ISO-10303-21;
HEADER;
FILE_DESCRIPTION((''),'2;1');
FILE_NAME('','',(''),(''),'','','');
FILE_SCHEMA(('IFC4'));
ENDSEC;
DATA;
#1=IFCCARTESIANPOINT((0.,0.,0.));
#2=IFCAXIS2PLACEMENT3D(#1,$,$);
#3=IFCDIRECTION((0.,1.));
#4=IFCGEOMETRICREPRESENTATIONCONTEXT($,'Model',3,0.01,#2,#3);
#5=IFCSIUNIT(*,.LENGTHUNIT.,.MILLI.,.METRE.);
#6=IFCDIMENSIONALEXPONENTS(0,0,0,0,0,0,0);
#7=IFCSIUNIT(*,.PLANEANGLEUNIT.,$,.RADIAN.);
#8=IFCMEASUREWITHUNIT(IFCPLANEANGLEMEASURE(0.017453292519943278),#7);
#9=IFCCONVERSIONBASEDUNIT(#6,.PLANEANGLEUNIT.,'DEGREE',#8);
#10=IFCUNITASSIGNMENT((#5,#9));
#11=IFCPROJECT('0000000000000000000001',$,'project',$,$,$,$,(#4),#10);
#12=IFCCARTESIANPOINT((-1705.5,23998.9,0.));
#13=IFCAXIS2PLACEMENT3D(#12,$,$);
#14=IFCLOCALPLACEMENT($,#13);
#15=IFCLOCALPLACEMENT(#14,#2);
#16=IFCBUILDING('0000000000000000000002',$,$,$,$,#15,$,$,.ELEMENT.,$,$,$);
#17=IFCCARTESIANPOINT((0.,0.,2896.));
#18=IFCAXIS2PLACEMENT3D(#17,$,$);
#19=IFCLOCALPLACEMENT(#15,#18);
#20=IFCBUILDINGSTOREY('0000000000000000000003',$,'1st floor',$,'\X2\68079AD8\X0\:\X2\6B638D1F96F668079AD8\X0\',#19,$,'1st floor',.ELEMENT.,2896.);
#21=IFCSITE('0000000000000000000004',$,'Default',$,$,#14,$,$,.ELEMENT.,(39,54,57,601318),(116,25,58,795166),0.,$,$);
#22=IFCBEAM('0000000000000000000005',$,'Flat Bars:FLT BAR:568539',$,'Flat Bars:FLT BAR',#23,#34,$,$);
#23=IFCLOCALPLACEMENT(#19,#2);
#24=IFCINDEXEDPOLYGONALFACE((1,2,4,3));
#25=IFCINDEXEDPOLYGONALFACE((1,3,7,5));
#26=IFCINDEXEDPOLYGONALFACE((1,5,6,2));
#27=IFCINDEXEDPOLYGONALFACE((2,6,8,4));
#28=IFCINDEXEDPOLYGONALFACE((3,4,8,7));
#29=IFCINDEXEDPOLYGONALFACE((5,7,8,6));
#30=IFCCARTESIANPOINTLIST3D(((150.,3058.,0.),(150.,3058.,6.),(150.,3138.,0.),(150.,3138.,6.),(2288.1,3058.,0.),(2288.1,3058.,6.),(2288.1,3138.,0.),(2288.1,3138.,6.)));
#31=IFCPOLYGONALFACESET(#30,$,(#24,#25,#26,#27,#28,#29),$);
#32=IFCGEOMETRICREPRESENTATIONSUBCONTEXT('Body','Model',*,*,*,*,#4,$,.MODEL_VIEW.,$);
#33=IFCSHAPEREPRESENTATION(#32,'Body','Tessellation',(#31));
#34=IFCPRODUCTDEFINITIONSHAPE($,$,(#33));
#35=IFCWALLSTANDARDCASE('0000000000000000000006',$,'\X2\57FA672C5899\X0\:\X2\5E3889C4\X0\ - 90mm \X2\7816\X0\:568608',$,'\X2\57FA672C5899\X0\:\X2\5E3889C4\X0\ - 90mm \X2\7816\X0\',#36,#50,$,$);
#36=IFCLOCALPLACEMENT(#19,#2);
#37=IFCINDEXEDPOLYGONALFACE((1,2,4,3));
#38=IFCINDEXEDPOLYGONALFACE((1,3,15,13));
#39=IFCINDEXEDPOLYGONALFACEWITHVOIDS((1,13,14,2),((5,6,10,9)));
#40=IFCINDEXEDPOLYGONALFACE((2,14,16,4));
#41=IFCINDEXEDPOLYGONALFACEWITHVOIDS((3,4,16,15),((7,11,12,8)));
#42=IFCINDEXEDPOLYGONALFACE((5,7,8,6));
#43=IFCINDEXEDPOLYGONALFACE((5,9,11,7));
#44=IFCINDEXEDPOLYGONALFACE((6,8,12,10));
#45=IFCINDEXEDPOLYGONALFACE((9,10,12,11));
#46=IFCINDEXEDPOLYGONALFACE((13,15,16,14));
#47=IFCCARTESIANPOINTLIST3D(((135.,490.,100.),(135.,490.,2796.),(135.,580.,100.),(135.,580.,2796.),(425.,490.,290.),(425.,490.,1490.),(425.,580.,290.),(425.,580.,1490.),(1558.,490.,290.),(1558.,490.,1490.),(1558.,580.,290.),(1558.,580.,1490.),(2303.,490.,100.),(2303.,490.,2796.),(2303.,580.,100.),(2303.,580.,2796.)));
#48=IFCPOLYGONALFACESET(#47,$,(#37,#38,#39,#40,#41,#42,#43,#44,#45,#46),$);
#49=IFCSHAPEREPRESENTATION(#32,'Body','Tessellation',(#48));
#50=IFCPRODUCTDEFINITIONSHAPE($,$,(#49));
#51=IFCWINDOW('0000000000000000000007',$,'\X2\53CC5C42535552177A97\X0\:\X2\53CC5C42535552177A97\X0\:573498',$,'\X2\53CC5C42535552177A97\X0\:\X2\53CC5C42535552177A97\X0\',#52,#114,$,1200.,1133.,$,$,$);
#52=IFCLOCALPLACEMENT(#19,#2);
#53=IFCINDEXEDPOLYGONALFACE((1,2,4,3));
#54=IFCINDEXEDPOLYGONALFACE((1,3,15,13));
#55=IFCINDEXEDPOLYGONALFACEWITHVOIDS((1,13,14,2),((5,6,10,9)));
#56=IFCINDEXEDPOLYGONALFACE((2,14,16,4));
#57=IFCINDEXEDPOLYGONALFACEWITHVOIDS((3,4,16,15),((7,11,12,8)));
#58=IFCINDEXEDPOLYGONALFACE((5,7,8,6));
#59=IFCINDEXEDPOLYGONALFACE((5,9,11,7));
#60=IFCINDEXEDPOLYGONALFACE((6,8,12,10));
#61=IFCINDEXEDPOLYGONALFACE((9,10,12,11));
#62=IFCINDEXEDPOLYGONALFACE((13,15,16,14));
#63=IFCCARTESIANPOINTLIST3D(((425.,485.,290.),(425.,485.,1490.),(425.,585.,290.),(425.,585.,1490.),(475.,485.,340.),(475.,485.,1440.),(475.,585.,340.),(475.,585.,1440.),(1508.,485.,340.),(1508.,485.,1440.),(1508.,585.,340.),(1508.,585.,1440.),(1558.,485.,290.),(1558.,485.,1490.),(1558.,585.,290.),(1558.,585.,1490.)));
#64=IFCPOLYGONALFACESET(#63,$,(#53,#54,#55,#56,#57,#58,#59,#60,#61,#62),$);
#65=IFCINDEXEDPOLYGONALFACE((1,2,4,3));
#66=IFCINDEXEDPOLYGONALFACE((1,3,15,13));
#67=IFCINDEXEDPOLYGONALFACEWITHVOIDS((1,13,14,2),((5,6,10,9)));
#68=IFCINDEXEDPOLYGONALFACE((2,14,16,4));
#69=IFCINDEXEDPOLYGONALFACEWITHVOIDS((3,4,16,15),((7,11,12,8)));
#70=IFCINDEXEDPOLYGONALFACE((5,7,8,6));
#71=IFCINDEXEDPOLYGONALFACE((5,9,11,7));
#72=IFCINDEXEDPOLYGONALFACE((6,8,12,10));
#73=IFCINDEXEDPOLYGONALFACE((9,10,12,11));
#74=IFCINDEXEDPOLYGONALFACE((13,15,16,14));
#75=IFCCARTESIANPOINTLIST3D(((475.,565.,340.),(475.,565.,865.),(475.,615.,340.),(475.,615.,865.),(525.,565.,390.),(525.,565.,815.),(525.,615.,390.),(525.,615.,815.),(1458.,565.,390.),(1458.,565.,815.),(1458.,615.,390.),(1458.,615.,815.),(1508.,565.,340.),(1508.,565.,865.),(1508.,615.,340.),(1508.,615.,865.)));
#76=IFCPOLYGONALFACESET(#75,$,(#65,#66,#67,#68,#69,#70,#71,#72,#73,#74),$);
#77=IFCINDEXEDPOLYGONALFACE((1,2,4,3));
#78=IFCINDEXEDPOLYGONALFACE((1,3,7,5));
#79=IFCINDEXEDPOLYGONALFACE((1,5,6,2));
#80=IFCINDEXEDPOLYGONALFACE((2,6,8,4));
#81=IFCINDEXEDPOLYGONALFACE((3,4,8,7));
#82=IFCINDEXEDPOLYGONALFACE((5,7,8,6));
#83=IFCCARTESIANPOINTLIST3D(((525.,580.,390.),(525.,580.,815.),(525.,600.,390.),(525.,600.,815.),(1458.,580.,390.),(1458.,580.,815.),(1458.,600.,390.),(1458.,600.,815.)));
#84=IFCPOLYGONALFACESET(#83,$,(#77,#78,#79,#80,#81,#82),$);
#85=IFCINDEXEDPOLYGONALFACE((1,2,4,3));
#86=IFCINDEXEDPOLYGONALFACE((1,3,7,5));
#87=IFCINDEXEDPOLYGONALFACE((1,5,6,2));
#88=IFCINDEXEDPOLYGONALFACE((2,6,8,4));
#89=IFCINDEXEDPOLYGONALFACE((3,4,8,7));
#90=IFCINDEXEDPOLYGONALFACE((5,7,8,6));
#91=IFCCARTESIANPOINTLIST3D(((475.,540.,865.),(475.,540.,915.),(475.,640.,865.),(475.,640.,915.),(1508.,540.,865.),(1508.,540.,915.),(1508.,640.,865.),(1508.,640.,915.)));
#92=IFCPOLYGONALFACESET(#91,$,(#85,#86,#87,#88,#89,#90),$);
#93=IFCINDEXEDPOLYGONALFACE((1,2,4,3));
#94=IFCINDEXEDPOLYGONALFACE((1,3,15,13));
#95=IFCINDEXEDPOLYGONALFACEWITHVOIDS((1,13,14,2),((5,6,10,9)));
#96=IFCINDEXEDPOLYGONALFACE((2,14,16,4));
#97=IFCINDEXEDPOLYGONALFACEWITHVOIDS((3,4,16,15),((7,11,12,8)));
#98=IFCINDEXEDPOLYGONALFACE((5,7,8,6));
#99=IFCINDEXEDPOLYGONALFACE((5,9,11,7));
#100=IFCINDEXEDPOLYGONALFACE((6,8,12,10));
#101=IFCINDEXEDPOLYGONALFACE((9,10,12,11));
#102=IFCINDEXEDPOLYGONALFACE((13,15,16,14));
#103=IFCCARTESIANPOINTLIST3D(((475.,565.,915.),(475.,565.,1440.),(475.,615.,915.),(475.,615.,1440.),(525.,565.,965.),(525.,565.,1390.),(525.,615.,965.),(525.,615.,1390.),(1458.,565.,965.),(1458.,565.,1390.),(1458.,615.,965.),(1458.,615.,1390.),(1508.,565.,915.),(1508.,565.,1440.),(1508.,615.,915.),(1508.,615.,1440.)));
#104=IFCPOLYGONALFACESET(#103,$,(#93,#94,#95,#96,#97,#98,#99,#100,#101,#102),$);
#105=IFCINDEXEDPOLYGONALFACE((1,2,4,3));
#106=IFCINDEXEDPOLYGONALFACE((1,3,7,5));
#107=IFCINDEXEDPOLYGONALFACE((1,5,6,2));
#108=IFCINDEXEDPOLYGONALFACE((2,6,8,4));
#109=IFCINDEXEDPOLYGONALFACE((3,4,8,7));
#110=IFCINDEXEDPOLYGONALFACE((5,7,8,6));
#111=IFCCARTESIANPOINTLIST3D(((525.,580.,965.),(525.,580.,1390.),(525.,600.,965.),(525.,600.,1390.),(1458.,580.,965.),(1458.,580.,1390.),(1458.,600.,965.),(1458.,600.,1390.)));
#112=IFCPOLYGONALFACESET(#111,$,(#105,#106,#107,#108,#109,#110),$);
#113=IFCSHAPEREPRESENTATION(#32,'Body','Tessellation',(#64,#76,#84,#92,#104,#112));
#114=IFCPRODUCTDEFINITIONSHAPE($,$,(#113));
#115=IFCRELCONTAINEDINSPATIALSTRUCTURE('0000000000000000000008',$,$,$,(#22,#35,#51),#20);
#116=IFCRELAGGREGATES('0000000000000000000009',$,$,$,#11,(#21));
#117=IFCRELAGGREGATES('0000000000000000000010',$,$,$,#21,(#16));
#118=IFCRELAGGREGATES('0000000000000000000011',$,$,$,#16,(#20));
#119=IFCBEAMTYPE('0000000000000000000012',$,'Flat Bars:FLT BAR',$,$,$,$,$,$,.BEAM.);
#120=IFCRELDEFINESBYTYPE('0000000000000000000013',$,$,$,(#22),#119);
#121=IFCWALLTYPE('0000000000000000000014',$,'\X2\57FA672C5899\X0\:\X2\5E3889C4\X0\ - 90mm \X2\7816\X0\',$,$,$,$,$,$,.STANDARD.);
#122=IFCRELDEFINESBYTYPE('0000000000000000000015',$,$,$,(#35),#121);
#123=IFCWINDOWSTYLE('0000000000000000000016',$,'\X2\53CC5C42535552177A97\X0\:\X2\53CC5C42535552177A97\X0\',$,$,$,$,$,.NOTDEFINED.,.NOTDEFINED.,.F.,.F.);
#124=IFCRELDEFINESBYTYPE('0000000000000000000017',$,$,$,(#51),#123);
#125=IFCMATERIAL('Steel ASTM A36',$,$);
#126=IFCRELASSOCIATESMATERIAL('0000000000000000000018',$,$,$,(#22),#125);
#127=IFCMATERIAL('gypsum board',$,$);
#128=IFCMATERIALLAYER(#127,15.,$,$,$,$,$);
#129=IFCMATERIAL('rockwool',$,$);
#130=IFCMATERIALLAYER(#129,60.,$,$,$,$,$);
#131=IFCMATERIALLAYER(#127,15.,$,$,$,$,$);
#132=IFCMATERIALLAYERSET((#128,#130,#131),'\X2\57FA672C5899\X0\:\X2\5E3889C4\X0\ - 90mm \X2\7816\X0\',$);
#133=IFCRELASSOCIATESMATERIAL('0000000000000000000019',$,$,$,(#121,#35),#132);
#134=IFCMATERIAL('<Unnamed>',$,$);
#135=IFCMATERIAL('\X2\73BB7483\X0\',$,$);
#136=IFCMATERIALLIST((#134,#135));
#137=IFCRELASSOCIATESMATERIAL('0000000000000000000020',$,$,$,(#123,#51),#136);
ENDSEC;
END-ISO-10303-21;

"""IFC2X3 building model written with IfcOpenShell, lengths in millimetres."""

from ifc_helpers import new_model, entity, si_unit, converted_unit, direction, frame, frame_2d, origin, origin_2d_with_axis, place, context, subcontext, project, spatial, polyline, rectangle, outline, extrude, source, transform, mapped, material, material_list, layer, layer_set, layer_usage, type_object, type_shapes, element, fill, save


model = new_model("IFC2X3")

# Units and contexts
model_context = context("Model", 3, precision=0.01, world=origin(), true_north=direction((0.0, 1.0)))
body_context = subcontext(model_context, "Body", "Model", "MODEL_VIEW")
ifc_project = project(units=[si_unit("LENGTHUNIT", "METRE", prefix="MILLI"), converted_unit("PLANEANGLEUNIT", "DEGREE", entity("IfcPlaneAngleMeasure", 0.017453292519943278), si_unit("PLANEANGLEUNIT", "RADIAN"), dimensions=[0, 0, 0, 0, 0, 0, 0])], contexts=[model_context])

# Site, building, storey
site_placement = place(None, frame((-1705.5, 23998.9, 0.0)))
site = spatial("IfcSite", under=ifc_project, at=site_placement, Name="Default", CompositionType="ELEMENT", RefLatitude=(39, 54, 57, 601318), RefLongitude=(116, 25, 58, 795166), RefElevation=0.0)
building_placement = place(site_placement, origin())
building = spatial("IfcBuilding", under=site, at=building_placement, CompositionType="ELEMENT")
storey_placement = place(building_placement, frame((0.0, 0.0, 2896.0)))
storey = spatial("IfcBuildingStorey", under=building, at=storey_placement, Name="1st floor", ObjectType="标高:正负零标高", LongName="1st floor", CompositionType="ELEMENT", Elevation=2896.0)

# Beam
ifc_material_1 = material(Name="Steel ASTM A36")
beam_type_1 = type_object("IfcBeamType", Name="Flat Bars:FLT BAR", PredefinedType="BEAM")
beam_1_placement = place(storey_placement, frame((150.0, 3098.0, 6.0)))
element("IfcBeam", 1, at=beam_1_placement, inside=storey, type_object=beam_type_1, material=ifc_material_1, Name="Flat Bars:FLT BAR:568539", ObjectType="Flat Bars:FLT BAR", context=body_context, shape_type="SweptSolid", body=[
    extrude(rectangle(XDim=6.0, YDim=80.0, at=origin_2d_with_axis()), frame((0.0, 0.0, -3.0), z_axis=(1.0, 0.0, 0.0), x_axis=(0.0, 0.0, -1.0)), (0.0, 0.0, 1.0), 2138.1),
])

# Wall, opening, window
ifc_material_2 = material(Name="gypsum board")
ifc_layer_1 = layer(ifc_material_2, 15.0)
ifc_material_3 = material(Name="rockwool")
ifc_layer_2 = layer(ifc_material_3, 60.0)
ifc_layer_3 = layer(ifc_material_2, 15.0)
ifc_layer_set = layer_set([ifc_layer_1, ifc_layer_2, ifc_layer_3], Name="基本墙:常规 - 90mm 砖")
ifc_layer_usage = layer_usage(ifc_layer_set, "AXIS2", "NEGATIVE", 45.0)
wall_type = type_object("IfcWallType", Name="基本墙:常规 - 90mm 砖", PredefinedType="STANDARD", material=ifc_layer_set)
wall_placement = place(storey_placement, frame((2303.0, 535.0, 100.0), z_axis=(0.0, 0.0, 1.0), x_axis=(-1.0, 0.0, 0.0)))
wall = element("IfcWallStandardCase", 2, at=wall_placement, inside=storey, type_object=wall_type, material=ifc_layer_usage, Name="基本墙:常规 - 90mm 砖:568608", ObjectType="基本墙:常规 - 90mm 砖", context=body_context, shape_type="SweptSolid", body=[
    extrude(rectangle(XDim=2168.0, YDim=90.0, at=frame_2d((1084.0, 0.0), x_axis=(-1.0, 0.0))), origin(), (0.0, 0.0, 1.0), 2696.0),
])
opening_1_placement = place(wall_placement, frame((1878.0, 45.0, 190.0)))
opening_1 = element("IfcOpeningElement", 3, at=opening_1_placement, cuts=wall, ObjectType="Opening", context=body_context, shape_type="SweptSolid", body=[
    extrude(rectangle(XDim=1200.0, YDim=1133.0, at=frame_2d((600.0, 566.5), x_axis=(1.0, 0.0))), frame((0.0, 0.0, 0.0), z_axis=(0.0, -1.0, 0.0), x_axis=(0.0, 0.0, 1.0)), (0.0, 0.0, 1.0), 90.0),
])
ifc_material_4 = material(Name="<Unnamed>")
ifc_material_5 = material(Name="玻璃")
ifc_material_list = material_list([ifc_material_4, ifc_material_5])
window_style = type_object("IfcWindowStyle", Name="双层单列窗:双层单列窗", ConstructionType="NOTDEFINED", OperationType="NOTDEFINED", ParameterTakesPrecedence=False, Sizeable=False, material=ifc_material_list)
shared_shape = source(origin(), body_context, "Body", "SweptSolid", [
    extrude(outline(polyline([(-600.0, -566.5), (600.0, -566.5), (600.0, 566.5), (-600.0, 566.5), (-600.0, -566.5)]), holes=[polyline([(-550.0, 516.5), (550.0, 516.5), (550.0, -516.5), (-550.0, -516.5), (-550.0, 516.5)])]), frame((566.5, 95.0, 600.0), z_axis=(0.0, -1.0, 0.0), x_axis=(0.0, 0.0, -1.0)), (0.0, 0.0, 1.0), 100.0),
    extrude(outline(polyline([(-262.5, -516.5), (262.5, -516.5), (262.5, 516.5), (-262.5, 516.5), (-262.5, -516.5)]), holes=[polyline([(-212.5, -466.5), (-212.5, 466.5), (212.5, 466.5), (212.5, -466.5), (-212.5, -466.5)])]), frame((566.5, 125.0, 312.5), z_axis=(0.0, -1.0, 0.0), x_axis=(0.0, 0.0, -1.0)), (0.0, 0.0, 1.0), 50.0),
    extrude(rectangle(XDim=933.0, YDim=20.0, at=origin_2d_with_axis()), frame((566.5, 100.0, 100.0)), (0.0, 0.0, 1.0), 425.0),
    extrude(rectangle(XDim=1033.0, YDim=100.0, at=origin_2d_with_axis()), frame((566.5, 100.0, 575.0)), (0.0, 0.0, 1.0), 50.0),
    extrude(outline(polyline([(-262.5, -516.5), (262.5, -516.5), (262.5, 516.5), (-262.5, 516.5), (-262.5, -516.5)]), holes=[polyline([(-212.5, -466.5), (-212.5, 466.5), (212.5, 466.5), (212.5, -466.5), (-212.5, -466.5)])]), frame((566.5, 125.0, 887.5), z_axis=(0.0, -1.0, 0.0), x_axis=(0.0, 0.0, -1.0)), (0.0, 0.0, 1.0), 50.0),
    extrude(rectangle(XDim=933.0, YDim=20.0, at=origin_2d_with_axis()), frame((566.5, 100.0, 675.0)), (0.0, 0.0, 1.0), 425.0),
])
type_shapes(window_style, [shared_shape])
window_placement = place(opening_1_placement, frame((0.0, 0.0, 0.0), z_axis=(0.0, 0.0, 1.0), x_axis=(-1.0, 0.0, 0.0)))
window = element("IfcWindow", 4, at=window_placement, inside=storey, type_object=window_style, material=ifc_material_list, Name="双层单列窗:双层单列窗:573498", ObjectType="双层单列窗:双层单列窗", OverallHeight=1200.0, OverallWidth=1133.0, context=body_context, shape_type="MappedRepresentation", body=[
    mapped(shared_shape, transform((0.0, 0.0, 0.0), scale=1.0)),
])
fill(opening_1, window)

save(model, "model.ifc")
